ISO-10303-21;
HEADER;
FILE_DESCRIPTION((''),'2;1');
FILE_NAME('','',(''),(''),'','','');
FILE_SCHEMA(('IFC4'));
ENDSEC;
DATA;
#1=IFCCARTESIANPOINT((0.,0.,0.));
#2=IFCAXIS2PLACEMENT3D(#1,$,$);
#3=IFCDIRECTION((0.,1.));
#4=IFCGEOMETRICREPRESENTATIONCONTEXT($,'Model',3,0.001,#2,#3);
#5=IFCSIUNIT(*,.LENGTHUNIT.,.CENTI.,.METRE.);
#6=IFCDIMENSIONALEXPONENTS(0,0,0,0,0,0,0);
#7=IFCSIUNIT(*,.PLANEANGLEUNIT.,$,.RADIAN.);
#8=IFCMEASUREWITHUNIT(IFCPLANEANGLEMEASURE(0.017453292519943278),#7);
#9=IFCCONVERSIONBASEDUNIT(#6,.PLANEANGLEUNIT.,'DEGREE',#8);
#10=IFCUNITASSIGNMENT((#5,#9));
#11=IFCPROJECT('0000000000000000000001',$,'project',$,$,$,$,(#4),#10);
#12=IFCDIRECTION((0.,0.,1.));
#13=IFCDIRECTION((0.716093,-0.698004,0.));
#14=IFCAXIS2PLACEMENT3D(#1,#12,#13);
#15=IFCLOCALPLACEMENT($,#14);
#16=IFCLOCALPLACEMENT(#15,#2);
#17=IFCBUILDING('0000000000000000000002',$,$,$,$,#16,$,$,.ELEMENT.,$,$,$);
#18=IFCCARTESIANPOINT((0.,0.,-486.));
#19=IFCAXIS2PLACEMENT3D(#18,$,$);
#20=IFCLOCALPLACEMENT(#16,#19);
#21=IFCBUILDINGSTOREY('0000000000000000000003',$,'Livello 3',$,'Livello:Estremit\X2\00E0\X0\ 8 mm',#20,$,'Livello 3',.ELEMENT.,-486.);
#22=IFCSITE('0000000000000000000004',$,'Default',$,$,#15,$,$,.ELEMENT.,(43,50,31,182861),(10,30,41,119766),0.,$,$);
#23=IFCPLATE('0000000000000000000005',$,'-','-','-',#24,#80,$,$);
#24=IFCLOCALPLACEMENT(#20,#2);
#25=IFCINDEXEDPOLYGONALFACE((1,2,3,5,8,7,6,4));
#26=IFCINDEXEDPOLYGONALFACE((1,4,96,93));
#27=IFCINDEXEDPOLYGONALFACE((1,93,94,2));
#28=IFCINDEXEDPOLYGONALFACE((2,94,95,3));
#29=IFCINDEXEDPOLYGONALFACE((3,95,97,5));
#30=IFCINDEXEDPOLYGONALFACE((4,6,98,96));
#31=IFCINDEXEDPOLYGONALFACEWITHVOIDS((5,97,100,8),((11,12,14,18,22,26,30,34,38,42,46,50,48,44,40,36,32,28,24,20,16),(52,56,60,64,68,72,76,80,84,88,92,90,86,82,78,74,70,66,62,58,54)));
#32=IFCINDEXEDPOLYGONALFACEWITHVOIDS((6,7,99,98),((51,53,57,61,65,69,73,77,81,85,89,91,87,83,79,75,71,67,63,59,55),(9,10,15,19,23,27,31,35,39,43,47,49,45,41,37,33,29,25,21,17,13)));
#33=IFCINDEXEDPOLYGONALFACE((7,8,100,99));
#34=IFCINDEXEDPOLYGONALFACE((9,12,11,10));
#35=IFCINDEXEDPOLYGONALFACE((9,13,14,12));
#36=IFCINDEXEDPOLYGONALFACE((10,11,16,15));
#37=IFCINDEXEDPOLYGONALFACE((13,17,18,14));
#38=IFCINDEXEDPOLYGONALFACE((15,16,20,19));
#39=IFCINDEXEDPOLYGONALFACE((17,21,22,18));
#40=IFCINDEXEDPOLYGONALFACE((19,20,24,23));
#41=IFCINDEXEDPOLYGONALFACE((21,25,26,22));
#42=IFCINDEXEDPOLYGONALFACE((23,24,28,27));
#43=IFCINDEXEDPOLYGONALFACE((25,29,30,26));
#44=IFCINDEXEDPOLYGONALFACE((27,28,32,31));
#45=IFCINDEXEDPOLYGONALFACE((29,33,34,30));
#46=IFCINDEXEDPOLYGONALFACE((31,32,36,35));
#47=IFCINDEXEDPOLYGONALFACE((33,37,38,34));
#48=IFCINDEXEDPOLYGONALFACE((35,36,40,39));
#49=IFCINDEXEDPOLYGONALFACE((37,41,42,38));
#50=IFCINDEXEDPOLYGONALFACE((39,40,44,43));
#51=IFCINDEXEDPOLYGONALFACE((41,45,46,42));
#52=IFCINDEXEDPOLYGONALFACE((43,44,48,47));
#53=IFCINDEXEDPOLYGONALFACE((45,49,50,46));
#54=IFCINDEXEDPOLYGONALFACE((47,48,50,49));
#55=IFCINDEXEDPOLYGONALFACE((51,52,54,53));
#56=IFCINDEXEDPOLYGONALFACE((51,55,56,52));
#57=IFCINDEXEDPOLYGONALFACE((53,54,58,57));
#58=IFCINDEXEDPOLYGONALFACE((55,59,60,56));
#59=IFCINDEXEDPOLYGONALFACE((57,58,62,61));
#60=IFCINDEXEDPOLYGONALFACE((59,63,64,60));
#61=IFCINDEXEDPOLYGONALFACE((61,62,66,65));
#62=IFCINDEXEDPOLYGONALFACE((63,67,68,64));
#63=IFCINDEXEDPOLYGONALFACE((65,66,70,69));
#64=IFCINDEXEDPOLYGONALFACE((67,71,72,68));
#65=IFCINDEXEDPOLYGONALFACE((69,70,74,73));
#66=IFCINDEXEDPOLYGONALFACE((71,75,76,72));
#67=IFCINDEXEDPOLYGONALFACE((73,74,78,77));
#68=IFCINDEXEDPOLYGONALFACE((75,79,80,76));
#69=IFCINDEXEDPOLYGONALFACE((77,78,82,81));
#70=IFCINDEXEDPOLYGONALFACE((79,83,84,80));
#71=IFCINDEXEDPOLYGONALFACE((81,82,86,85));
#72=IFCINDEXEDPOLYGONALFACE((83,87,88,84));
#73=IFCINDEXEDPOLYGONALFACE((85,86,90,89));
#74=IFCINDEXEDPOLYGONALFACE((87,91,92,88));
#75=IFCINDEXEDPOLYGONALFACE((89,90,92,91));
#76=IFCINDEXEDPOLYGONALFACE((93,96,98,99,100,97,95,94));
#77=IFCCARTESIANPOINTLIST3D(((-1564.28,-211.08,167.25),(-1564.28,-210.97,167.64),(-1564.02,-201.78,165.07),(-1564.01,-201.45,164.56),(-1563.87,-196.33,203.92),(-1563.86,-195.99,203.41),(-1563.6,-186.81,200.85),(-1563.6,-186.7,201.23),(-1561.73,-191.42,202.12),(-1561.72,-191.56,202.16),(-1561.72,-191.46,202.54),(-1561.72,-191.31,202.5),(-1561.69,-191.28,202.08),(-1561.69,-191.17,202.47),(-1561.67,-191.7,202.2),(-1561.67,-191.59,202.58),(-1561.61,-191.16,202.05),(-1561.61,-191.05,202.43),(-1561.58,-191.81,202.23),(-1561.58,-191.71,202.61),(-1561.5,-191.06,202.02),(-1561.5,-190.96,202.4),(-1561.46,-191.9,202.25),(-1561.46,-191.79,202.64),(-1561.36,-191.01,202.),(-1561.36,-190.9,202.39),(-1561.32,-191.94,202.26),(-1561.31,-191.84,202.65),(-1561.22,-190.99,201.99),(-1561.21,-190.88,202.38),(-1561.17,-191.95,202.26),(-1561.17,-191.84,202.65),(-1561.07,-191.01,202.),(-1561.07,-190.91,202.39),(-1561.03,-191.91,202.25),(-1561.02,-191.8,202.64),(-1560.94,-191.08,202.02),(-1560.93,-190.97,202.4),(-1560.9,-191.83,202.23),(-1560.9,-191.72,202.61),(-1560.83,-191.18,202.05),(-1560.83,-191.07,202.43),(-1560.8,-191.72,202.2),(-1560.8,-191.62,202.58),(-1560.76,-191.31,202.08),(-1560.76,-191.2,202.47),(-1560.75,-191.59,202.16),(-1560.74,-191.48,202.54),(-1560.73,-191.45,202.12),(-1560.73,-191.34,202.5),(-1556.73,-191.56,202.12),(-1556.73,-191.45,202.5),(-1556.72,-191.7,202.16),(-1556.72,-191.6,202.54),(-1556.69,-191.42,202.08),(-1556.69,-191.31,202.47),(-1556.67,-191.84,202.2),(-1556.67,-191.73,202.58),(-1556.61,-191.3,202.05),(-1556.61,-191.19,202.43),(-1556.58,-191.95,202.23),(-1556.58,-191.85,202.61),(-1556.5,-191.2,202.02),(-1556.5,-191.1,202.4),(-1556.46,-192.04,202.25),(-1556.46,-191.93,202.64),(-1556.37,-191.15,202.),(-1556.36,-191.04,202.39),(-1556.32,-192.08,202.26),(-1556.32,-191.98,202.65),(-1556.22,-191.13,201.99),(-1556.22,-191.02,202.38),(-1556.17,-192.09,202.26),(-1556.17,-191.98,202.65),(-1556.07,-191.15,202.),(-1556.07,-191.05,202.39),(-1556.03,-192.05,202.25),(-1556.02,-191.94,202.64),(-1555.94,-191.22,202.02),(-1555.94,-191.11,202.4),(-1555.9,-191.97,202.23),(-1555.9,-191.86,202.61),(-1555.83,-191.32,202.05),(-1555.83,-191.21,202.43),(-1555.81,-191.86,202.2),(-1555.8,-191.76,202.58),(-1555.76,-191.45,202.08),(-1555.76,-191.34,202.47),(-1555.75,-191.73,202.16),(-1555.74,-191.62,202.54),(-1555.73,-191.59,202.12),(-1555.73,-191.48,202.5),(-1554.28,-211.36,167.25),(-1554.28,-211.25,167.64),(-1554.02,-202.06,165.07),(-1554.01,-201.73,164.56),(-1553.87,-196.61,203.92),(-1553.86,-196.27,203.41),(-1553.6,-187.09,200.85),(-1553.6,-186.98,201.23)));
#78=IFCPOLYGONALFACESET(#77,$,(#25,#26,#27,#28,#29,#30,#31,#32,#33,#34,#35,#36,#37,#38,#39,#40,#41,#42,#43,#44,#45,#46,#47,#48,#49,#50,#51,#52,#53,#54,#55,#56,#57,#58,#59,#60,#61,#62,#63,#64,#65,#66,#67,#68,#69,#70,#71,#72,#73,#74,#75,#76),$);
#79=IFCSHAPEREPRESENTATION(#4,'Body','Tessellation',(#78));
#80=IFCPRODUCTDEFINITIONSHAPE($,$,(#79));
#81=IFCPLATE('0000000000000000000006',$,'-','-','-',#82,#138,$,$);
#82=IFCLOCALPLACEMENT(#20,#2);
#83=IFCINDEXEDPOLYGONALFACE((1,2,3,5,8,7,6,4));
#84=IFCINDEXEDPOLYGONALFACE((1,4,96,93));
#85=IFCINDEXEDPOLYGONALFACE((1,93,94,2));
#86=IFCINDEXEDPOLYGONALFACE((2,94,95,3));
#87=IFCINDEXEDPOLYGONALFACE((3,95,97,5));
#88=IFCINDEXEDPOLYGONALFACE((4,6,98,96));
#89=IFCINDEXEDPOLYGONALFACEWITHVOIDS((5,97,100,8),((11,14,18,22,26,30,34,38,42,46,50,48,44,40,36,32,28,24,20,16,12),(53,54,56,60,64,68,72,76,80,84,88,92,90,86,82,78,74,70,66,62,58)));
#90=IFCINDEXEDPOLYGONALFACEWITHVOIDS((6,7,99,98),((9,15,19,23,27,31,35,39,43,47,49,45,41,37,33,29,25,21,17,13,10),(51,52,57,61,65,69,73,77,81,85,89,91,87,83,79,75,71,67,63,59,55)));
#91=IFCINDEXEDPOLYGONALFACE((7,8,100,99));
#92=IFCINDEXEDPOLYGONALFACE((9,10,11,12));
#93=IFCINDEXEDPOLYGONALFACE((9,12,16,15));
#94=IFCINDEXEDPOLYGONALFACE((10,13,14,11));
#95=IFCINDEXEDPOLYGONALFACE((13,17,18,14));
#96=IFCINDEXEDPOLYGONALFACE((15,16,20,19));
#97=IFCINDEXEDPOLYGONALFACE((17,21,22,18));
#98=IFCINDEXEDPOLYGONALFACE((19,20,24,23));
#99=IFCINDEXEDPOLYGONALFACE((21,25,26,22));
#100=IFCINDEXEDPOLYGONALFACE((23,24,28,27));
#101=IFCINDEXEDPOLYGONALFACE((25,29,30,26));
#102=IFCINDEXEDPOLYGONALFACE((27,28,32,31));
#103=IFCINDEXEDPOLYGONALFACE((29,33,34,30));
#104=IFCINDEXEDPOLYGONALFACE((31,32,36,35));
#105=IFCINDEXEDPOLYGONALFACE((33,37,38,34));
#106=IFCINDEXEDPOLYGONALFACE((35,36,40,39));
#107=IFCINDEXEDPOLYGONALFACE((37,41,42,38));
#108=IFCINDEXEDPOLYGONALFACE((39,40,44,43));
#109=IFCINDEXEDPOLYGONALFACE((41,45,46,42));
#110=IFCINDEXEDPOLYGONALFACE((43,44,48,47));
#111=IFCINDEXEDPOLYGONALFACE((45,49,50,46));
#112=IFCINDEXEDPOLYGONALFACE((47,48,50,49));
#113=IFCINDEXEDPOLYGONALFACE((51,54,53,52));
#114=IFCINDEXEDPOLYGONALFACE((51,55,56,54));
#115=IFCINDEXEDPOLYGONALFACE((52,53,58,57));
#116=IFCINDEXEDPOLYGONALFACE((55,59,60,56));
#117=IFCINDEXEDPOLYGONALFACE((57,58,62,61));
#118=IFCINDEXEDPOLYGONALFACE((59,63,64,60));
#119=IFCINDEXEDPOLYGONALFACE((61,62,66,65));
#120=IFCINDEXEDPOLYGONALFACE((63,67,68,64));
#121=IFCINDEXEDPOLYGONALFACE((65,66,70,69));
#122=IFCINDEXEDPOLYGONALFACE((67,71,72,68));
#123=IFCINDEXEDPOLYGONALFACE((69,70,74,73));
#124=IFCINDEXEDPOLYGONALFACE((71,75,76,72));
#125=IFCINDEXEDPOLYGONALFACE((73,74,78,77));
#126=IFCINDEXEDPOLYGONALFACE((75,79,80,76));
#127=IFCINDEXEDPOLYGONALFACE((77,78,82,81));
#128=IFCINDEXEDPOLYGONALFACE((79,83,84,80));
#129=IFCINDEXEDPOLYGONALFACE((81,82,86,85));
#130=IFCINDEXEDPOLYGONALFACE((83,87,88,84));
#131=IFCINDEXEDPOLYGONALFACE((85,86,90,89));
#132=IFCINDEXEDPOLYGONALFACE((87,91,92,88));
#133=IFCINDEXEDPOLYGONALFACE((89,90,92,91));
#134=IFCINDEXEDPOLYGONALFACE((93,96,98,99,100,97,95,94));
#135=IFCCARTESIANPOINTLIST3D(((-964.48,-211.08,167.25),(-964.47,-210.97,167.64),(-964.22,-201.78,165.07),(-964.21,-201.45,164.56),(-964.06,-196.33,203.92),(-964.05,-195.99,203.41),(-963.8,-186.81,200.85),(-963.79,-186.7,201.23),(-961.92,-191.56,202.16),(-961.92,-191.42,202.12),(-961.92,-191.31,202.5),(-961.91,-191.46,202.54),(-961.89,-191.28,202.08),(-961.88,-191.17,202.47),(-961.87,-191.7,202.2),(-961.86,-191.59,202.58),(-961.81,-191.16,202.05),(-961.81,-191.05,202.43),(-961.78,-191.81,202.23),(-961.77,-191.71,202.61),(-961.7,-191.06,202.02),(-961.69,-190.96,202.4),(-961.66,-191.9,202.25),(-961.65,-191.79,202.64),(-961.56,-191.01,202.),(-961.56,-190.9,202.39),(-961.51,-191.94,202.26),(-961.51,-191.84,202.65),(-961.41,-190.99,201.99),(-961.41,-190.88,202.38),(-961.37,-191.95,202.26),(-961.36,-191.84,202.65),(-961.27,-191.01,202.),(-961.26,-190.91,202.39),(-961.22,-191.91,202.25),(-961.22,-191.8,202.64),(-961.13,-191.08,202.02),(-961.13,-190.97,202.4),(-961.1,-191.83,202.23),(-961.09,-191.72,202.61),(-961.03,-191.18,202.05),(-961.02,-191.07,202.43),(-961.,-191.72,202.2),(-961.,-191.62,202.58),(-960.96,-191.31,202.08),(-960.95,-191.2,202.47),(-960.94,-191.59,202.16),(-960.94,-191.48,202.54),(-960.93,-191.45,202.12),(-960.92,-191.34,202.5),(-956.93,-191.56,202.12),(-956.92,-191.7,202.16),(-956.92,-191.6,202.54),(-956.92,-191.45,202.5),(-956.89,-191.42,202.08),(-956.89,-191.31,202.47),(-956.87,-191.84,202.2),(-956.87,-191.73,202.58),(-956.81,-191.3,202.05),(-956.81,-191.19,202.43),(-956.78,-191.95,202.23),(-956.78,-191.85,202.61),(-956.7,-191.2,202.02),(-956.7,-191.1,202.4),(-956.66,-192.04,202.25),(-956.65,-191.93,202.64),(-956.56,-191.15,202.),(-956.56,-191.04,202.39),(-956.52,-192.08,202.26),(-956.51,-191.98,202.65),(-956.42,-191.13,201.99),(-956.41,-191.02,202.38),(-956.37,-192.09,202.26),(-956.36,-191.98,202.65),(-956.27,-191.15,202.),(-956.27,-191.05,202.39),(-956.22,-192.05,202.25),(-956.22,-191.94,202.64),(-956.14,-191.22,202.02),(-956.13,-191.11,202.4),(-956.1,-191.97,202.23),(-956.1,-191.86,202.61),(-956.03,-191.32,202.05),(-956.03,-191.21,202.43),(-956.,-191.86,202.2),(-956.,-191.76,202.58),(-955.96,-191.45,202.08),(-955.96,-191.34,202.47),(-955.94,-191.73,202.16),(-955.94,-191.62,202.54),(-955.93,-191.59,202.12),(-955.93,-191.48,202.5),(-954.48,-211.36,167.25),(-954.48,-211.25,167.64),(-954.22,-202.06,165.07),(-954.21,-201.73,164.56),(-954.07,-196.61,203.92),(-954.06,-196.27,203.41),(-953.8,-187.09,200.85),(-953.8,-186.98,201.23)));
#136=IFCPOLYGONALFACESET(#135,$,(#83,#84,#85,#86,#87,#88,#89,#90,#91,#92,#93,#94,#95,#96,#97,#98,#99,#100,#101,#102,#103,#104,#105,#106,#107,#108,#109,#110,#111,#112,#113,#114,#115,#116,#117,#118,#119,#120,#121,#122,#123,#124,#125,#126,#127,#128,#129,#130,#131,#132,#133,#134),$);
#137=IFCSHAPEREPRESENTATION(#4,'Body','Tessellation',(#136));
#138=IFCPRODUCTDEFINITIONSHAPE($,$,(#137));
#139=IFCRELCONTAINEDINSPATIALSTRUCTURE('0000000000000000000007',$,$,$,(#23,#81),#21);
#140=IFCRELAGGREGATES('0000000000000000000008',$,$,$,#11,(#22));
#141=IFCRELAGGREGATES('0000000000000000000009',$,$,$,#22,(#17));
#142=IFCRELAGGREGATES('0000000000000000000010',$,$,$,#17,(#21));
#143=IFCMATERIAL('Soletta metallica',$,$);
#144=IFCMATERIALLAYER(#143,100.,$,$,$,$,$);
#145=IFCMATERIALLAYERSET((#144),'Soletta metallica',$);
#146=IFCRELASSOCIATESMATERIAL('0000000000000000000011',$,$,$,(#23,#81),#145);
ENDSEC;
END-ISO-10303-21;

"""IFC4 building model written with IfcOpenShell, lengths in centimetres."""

from ifc_helpers import new_model, entity, si_unit, converted_unit, direction, frame, frame_2d, origin, origin_with_axes, place, context, project, spatial, polyline, circle, outline, extrude, material, layer, layer_set, element, save


model = new_model("IFC4")

# Units and contexts
model_context = context("Model", 3, precision=0.001, world=origin(), true_north=direction((0.0, 1.0)))
ifc_project = project(units=[si_unit("LENGTHUNIT", "METRE", prefix="CENTI"), converted_unit("PLANEANGLEUNIT", "DEGREE", entity("IfcPlaneAngleMeasure", 0.017453292519943278), si_unit("PLANEANGLEUNIT", "RADIAN"), dimensions=[0, 0, 0, 0, 0, 0, 0])], contexts=[model_context])

# Site, building, storey
site_placement = place(None, frame((0.0, 0.0, 0.0), z_axis=(0.0, 0.0, 1.0), x_axis=(0.716093, -0.698004, 0.0)))
site = spatial("IfcSite", under=ifc_project, at=site_placement, Name="Default", CompositionType="ELEMENT", RefLatitude=(43, 50, 31, 182861), RefLongitude=(10, 30, 41, 119766), RefElevation=0.0)
building_placement = place(site_placement, origin())
building = spatial("IfcBuilding", under=site, at=building_placement, CompositionType="ELEMENT")
storey_placement = place(building_placement, frame((0.0, 0.0, -486.0)))
storey = spatial("IfcBuildingStorey", under=building, at=storey_placement, Name="Livello 3", ObjectType="Livello:Estremità 8 mm", LongName="Livello 3", CompositionType="ELEMENT", Elevation=-486.0)

# Plates, openings
ifc_material_1 = material(Name="Soletta metallica")
ifc_layer_1 = layer(ifc_material_1, 100.0)
ifc_layer_set_1 = layer_set([ifc_layer_1], Name="Soletta metallica")
plate_1_placement = place(storey_placement, frame((-1553.56, -185.55, 200.87), z_axis=(-0.999608, 0.02798, 0.0), x_axis=(-0.02798, -0.999608, 0.0)))
plate_1 = element("IfcPlate", 1, at=plate_1_placement, inside=storey, material=ifc_layer_set_1, Name="-", Description="-", ObjectType="-", context=model_context, shape_type="SweptSolid", body=[
    extrude(outline(polyline([(1.54, -0.03), (10.73, 2.54), (16.19, -36.31), (25.82, -33.62), (25.71, -33.24), (16.52, -35.8), (11.06, 3.05), (1.43, 0.36), (1.54, -0.03)])), origin_with_axes(), (0.0, 0.0, 1.0), 10.0),
])
opening_1_placement = place(plate_1_placement, frame((5.78, 2.51, 3.0), z_axis=(-0.268612, 0.963248, 0.0), x_axis=(-0.963248, -0.268612, 0.0)))
element("IfcOpeningElement", 2, at=opening_1_placement, cuts=plate_1, ObjectType="Opening", context=model_context, shape_type="SweptSolid", body=[
    extrude(circle(Radius=0.5, at=frame_2d((0.0, -0.5), x_axis=(1.0, 0.0))), origin(), (0.0, 0.0, -1.0), 1.35),
])
opening_2_placement = place(plate_1_placement, frame((5.78, 2.51, 8.0), z_axis=(-0.268612, 0.963248, 0.0), x_axis=(-0.963248, -0.268612, 0.0)))
element("IfcOpeningElement", 3, at=opening_2_placement, cuts=plate_1, ObjectType="Opening", context=model_context, shape_type="SweptSolid", body=[
    extrude(circle(Radius=0.5, at=frame_2d((0.0, -0.5), x_axis=(1.0, 0.0))), origin(), (0.0, 0.0, -1.0), 1.35),
])
plate_2_placement = place(storey_placement, frame((-953.76, -185.55, 200.87), z_axis=(-0.999608, 0.02798, 0.0), x_axis=(-0.02798, -0.999608, 0.0)))
plate_2 = element("IfcPlate", 4, at=plate_2_placement, inside=storey, material=ifc_layer_set_1, Name="-", Description="-", ObjectType="-", context=model_context, shape_type="SweptSolid", body=[
    extrude(outline(polyline([(1.54, -0.03), (10.73, 2.54), (16.19, -36.31), (25.82, -33.62), (25.71, -33.24), (16.52, -35.8), (11.06, 3.05), (1.43, 0.36), (1.54, -0.03)])), origin_with_axes(), (0.0, 0.0, 1.0), 10.0),
])
opening_3_placement = place(plate_2_placement, frame((5.78, 2.51, 3.0), z_axis=(-0.268612, 0.963248, 0.0), x_axis=(-0.963248, -0.268612, 0.0)))
element("IfcOpeningElement", 5, at=opening_3_placement, cuts=plate_2, ObjectType="Opening", context=model_context, shape_type="SweptSolid", body=[
    extrude(circle(Radius=0.5, at=frame_2d((0.0, -0.5), x_axis=(1.0, 0.0))), origin(), (0.0, 0.0, -1.0), 1.35),
])
opening_4_placement = place(plate_2_placement, frame((5.78, 2.51, 8.0), z_axis=(-0.268612, 0.963248, 0.0), x_axis=(-0.963248, -0.268612, 0.0)))
element("IfcOpeningElement", 6, at=opening_4_placement, cuts=plate_2, ObjectType="Opening", context=model_context, shape_type="SweptSolid", body=[
    extrude(circle(Radius=0.5, at=frame_2d((0.0, -0.5), x_axis=(1.0, 0.0))), origin(), (0.0, 0.0, -1.0), 1.35),
])

save(model, "model.ifc")
